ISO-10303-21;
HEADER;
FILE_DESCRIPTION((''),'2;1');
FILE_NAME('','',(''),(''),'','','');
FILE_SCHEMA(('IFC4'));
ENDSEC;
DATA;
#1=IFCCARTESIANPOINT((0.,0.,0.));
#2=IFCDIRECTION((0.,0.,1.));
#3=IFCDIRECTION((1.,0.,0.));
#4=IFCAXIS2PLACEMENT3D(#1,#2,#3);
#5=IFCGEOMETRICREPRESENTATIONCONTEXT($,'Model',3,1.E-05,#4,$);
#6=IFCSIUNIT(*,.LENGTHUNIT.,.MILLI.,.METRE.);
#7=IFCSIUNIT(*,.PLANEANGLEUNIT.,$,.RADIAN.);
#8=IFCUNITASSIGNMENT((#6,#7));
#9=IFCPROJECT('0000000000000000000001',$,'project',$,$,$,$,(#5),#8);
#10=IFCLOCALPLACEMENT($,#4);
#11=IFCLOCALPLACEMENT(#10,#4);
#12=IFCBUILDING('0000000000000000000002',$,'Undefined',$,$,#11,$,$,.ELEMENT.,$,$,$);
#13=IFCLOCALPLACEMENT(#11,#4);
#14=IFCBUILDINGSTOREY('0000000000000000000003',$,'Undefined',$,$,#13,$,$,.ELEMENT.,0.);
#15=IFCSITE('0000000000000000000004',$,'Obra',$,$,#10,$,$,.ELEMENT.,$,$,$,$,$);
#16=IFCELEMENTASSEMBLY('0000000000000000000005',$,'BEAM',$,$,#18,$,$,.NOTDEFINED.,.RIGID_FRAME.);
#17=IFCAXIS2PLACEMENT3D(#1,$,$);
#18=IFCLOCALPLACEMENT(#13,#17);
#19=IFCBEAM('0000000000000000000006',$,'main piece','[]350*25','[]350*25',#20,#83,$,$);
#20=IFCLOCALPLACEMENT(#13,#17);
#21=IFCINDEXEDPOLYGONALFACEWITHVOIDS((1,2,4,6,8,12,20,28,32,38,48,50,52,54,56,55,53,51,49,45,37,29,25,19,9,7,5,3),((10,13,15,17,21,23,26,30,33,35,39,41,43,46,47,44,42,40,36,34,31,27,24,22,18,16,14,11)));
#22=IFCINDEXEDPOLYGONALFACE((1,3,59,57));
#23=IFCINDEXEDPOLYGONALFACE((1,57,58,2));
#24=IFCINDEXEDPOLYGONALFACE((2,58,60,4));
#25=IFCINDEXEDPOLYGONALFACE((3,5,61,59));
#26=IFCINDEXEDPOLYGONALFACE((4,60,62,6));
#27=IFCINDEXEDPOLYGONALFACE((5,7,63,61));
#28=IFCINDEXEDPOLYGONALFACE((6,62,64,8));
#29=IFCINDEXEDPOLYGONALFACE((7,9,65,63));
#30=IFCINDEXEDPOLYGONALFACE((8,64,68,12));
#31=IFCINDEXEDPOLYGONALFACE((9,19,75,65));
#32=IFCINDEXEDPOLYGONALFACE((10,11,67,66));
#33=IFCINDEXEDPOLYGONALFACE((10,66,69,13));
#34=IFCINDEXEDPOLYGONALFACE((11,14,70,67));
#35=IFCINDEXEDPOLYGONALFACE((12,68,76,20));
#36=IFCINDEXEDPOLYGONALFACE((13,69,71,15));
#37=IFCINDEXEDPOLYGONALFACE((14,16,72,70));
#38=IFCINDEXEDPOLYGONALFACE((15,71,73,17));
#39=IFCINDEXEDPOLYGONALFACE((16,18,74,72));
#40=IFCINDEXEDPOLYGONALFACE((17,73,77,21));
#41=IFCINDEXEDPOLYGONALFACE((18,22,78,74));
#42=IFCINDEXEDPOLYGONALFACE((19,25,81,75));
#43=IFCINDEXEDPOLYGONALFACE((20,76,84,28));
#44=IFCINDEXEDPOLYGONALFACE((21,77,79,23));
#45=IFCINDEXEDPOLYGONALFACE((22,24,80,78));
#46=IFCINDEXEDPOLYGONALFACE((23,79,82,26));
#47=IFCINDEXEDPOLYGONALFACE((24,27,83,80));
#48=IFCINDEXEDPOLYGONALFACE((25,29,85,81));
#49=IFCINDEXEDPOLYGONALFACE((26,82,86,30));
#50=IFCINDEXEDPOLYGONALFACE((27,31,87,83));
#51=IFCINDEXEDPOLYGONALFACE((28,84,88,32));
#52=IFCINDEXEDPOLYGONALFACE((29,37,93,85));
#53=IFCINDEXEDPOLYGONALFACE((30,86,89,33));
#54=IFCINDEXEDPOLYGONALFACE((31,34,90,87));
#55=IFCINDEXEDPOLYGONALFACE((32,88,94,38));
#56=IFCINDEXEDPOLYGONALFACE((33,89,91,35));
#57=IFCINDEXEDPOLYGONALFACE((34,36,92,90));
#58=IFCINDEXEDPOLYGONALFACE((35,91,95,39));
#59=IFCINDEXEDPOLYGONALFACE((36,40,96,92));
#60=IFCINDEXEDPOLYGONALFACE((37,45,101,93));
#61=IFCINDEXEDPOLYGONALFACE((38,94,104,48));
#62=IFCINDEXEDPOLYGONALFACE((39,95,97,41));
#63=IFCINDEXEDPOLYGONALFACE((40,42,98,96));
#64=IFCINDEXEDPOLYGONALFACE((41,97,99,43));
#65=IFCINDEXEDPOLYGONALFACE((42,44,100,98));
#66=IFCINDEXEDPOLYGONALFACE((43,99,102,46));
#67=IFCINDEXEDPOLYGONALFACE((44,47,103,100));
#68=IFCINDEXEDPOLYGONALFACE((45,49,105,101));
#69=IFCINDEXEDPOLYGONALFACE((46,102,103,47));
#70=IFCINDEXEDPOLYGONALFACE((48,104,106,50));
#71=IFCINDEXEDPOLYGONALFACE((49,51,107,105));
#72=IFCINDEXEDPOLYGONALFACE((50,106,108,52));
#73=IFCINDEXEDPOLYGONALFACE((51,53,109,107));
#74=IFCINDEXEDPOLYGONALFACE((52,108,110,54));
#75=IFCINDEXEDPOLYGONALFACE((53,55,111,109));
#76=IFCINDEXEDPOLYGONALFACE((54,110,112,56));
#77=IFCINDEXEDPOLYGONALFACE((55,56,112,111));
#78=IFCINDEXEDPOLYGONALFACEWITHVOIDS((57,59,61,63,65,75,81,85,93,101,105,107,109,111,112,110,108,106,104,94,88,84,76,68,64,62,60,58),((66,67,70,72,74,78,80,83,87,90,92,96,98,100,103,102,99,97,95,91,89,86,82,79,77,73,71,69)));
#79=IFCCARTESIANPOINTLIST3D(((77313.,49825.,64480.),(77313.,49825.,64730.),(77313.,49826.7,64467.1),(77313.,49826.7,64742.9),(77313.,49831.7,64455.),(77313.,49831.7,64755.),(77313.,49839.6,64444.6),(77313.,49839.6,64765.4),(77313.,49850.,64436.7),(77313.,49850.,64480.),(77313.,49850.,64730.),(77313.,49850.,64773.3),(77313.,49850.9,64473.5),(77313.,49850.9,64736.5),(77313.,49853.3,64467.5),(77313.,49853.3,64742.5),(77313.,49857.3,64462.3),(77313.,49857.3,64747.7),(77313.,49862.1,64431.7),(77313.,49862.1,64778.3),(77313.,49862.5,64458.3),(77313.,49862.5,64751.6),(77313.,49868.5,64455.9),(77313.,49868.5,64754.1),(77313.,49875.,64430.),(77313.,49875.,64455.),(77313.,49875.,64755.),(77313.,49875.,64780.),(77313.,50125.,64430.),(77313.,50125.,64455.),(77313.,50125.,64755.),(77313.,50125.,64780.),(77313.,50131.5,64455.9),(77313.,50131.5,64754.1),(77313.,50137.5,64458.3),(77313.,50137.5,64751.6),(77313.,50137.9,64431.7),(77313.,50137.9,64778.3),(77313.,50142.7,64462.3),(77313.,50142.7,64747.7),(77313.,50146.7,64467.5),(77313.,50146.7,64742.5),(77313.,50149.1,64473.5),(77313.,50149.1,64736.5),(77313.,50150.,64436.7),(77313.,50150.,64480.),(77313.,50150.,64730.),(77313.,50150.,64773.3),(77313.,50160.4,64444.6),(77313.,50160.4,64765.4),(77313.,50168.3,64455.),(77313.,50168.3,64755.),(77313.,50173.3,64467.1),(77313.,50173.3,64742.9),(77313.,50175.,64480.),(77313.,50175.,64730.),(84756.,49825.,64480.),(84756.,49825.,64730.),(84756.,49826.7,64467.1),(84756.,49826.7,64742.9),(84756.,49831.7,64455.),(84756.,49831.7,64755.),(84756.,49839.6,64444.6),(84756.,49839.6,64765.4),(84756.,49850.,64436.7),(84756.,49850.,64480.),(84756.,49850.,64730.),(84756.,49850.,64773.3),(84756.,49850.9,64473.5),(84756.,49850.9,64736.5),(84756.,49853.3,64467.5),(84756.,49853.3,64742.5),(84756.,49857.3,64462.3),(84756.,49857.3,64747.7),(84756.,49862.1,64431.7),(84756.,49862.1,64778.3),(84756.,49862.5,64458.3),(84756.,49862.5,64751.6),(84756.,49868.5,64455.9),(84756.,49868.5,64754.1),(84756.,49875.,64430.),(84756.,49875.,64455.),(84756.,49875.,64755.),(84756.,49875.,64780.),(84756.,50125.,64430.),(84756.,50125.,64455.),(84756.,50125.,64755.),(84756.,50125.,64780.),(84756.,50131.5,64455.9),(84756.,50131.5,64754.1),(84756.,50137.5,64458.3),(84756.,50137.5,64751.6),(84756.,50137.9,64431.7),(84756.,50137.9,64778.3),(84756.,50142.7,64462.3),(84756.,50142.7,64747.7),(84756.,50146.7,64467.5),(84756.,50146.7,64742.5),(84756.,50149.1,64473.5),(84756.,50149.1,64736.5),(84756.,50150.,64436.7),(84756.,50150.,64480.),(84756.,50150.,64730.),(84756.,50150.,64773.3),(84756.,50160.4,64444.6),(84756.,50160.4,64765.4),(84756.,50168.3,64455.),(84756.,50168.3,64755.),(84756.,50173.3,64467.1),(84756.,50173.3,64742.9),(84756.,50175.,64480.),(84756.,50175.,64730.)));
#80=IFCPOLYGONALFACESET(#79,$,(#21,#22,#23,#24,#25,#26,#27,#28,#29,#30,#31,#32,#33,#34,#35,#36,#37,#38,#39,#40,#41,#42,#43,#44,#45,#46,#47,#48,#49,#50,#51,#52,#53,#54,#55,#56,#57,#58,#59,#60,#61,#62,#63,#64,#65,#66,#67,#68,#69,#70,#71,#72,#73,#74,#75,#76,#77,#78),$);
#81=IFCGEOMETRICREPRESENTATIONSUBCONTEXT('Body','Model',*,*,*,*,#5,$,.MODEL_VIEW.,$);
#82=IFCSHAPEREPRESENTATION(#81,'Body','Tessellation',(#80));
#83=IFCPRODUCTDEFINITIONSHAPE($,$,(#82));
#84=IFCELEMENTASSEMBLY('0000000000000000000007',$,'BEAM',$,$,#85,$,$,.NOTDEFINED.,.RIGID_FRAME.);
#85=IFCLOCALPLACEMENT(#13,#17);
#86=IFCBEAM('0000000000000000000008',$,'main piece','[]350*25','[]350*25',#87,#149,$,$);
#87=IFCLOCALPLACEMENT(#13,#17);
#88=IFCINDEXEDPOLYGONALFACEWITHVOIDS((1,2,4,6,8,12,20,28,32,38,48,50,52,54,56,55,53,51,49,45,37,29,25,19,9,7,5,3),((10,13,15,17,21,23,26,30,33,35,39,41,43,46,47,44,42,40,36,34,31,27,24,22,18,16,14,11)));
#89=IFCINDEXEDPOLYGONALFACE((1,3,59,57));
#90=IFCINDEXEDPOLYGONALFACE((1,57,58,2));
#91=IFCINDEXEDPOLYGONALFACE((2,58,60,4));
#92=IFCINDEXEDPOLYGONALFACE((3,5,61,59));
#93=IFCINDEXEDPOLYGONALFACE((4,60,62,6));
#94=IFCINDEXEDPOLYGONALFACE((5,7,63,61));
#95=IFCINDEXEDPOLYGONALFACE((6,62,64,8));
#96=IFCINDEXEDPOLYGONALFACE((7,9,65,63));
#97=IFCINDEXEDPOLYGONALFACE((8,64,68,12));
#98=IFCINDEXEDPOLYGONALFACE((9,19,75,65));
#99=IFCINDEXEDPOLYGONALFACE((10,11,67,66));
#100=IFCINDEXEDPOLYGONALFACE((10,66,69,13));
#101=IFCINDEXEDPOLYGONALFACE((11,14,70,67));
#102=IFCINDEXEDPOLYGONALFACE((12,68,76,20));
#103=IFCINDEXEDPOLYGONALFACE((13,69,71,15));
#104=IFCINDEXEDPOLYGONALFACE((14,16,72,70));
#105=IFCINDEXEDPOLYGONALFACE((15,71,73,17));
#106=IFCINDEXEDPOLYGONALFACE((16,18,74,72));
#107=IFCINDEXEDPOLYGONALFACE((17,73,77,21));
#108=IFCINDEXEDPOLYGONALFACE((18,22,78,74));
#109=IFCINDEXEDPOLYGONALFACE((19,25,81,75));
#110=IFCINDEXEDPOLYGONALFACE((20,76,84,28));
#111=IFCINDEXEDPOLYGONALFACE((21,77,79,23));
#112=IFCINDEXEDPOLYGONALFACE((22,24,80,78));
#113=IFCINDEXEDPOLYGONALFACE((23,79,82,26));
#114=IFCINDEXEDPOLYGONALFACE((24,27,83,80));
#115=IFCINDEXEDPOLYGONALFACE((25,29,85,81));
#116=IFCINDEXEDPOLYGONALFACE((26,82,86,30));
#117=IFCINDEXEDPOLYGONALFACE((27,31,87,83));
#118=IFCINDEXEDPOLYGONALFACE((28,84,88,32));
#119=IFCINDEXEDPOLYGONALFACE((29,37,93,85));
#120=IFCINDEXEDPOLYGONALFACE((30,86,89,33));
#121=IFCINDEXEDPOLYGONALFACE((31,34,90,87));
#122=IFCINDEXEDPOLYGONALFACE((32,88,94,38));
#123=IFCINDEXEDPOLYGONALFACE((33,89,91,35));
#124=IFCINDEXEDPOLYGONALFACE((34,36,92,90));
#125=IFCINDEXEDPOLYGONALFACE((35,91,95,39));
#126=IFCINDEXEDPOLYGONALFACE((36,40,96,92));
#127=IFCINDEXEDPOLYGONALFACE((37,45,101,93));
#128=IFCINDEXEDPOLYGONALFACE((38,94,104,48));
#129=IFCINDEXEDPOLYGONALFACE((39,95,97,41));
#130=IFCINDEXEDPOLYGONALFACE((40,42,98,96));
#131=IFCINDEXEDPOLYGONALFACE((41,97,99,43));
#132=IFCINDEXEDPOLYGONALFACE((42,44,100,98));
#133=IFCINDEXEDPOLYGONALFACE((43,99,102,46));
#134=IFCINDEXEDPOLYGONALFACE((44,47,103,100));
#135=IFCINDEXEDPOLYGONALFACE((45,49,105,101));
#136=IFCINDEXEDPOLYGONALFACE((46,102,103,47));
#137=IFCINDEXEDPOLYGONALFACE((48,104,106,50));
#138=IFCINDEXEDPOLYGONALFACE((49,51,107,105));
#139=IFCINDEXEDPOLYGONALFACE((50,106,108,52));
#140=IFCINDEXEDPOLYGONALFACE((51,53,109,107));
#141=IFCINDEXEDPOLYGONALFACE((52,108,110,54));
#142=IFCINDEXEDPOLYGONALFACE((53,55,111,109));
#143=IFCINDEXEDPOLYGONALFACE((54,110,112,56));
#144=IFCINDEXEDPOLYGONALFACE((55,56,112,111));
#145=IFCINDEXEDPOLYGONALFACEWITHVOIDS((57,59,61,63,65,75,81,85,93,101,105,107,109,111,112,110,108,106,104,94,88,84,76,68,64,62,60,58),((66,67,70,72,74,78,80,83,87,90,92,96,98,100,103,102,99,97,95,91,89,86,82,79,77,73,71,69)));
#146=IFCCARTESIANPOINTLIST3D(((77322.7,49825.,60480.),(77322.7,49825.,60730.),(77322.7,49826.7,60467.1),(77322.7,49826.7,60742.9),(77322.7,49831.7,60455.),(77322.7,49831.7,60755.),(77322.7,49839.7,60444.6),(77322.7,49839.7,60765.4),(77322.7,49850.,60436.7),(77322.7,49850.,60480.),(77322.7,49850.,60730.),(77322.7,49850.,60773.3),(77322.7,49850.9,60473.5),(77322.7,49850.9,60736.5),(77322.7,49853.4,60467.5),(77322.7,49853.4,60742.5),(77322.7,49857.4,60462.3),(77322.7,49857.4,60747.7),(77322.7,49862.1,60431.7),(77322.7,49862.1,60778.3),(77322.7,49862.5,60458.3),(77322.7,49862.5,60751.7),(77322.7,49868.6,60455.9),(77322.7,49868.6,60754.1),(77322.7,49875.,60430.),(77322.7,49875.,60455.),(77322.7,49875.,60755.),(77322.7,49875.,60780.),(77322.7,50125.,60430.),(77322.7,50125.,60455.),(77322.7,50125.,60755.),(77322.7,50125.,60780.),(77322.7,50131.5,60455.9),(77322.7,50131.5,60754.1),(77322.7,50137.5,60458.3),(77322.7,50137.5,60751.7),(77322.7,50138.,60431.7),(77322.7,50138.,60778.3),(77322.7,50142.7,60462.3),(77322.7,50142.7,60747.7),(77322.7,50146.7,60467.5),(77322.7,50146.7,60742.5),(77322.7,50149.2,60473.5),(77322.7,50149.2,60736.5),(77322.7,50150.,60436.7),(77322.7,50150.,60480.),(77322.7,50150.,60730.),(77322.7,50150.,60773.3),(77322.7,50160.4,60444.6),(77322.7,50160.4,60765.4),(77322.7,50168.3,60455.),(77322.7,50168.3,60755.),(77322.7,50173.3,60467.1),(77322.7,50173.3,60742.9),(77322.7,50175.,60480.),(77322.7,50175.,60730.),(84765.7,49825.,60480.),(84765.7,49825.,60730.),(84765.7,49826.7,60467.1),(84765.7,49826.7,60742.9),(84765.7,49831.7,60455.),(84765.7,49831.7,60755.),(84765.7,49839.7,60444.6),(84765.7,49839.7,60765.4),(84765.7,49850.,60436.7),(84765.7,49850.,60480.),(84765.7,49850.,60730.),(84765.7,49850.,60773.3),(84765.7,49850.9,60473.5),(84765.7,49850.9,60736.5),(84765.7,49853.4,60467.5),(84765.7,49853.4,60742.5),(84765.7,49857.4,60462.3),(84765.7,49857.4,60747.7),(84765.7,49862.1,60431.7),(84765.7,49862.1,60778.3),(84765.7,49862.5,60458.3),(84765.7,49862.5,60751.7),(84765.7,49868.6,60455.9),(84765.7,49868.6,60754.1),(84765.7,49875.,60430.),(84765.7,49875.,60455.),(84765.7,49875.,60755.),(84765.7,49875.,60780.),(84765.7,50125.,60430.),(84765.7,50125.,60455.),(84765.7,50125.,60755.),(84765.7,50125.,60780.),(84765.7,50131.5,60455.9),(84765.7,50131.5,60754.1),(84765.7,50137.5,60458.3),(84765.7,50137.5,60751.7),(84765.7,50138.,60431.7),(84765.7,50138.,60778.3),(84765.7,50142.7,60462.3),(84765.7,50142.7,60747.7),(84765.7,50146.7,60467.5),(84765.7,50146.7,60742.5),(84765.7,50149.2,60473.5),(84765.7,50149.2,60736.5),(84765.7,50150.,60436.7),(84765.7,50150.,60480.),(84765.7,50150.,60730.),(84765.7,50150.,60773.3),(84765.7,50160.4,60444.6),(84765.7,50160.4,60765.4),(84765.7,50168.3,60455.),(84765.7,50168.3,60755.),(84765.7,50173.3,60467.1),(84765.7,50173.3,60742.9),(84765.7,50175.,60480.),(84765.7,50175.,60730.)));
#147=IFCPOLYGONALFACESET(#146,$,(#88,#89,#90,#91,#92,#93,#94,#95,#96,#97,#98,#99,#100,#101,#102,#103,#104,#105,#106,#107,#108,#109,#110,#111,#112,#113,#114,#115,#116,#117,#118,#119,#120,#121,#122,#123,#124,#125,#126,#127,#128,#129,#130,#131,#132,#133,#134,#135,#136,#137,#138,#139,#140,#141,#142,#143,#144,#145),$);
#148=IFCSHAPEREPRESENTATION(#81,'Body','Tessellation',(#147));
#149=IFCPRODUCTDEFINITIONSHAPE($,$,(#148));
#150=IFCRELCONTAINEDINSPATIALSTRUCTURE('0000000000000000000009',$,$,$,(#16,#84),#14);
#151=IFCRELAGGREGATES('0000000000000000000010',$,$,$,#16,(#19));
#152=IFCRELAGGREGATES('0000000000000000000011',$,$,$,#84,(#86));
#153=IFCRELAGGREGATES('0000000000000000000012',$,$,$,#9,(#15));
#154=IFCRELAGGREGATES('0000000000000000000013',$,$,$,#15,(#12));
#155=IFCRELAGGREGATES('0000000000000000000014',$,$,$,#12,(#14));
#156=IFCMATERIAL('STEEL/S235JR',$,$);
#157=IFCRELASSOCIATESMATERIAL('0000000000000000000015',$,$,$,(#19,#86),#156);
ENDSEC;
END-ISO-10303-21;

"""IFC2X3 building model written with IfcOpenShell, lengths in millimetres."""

from ifc_helpers import new_model, si_unit, frame, origin_with_axes, origin_2d_with_axis, place, context, subcontext, project, spatial, hollow_rectangle, extrude, material, element, aggregate, save


model = new_model("IFC2X3")

# Units and contexts
model_context = context("Model", 3, precision=1e-05, world=origin_with_axes())
body_context = subcontext(model_context, "Body", "Model", "MODEL_VIEW")
ifc_project = project(units=[si_unit("LENGTHUNIT", "METRE", prefix="MILLI"), si_unit("PLANEANGLEUNIT", "RADIAN")], contexts=[model_context])

# Site, building, storey
site_placement = place(None, origin_with_axes())
site = spatial("IfcSite", under=ifc_project, at=site_placement, Name="Obra", CompositionType="ELEMENT")
building_placement = place(site_placement, origin_with_axes())
building = spatial("IfcBuilding", under=site, at=building_placement, Name="Undefined", CompositionType="ELEMENT")
storey_placement = place(building_placement, origin_with_axes())
storey = spatial("IfcBuildingStorey", under=building, at=storey_placement, Name="Undefined", CompositionType="ELEMENT", Elevation=0.0)

# Shared definitions
ifc_material = material(Name="STEEL/S235JR")

# Element assemblies, beams
assembly_1_placement = place(storey_placement, origin_with_axes())
assembly_1 = element("IfcElementAssembly", 1, at=assembly_1_placement, inside=storey, Name="BEAM", AssemblyPlace="NOTDEFINED", PredefinedType="RIGID_FRAME")
beam_1_placement = place(assembly_1_placement, frame((84756.0, 50000.0, 64605.0), z_axis=(0.0, 0.0, 1.0), x_axis=(-1.0, 0.0, 0.0)))
beam_1 = element("IfcBeam", 2, at=beam_1_placement, material=ifc_material, Name="main piece", Description="[]350*25", ObjectType="[]350*25", context=body_context, shape_type="SweptSolid", body=[
    extrude(hollow_rectangle(XDim=350.0, YDim=350.0, WallThickness=25.0, InnerFilletRadius=25.0, OuterFilletRadius=50.0, at=origin_2d_with_axis()), frame((7443.0, 0.0, 0.0), z_axis=(-1.0, 0.0, 0.0), x_axis=(0.0, -1.0, 0.0)), (0.0, 0.0, 1.0), 7443.0),
])
aggregate(assembly_1, [beam_1])
assembly_2_placement = place(storey_placement, origin_with_axes())
assembly_2 = element("IfcElementAssembly", 3, at=assembly_2_placement, inside=storey, Name="BEAM", AssemblyPlace="NOTDEFINED", PredefinedType="RIGID_FRAME")
beam_2_placement = place(assembly_2_placement, frame((84765.7, 50000.0, 60605.0), z_axis=(0.0, 0.0, 1.0), x_axis=(-1.0, 0.0, 0.0)))
beam_2 = element("IfcBeam", 4, at=beam_2_placement, material=ifc_material, Name="main piece", Description="[]350*25", ObjectType="[]350*25", context=body_context, shape_type="SweptSolid", body=[
    extrude(hollow_rectangle(XDim=350.0, YDim=350.0, WallThickness=25.0, InnerFilletRadius=25.0, OuterFilletRadius=50.0, at=origin_2d_with_axis()), frame((7443.0, 0.0, 0.0), z_axis=(-1.0, 0.0, 0.0), x_axis=(0.0, -1.0, 0.0)), (0.0, 0.0, 1.0), 7443.0),
])
aggregate(assembly_2, [beam_2])

save(model, "model.ifc")
